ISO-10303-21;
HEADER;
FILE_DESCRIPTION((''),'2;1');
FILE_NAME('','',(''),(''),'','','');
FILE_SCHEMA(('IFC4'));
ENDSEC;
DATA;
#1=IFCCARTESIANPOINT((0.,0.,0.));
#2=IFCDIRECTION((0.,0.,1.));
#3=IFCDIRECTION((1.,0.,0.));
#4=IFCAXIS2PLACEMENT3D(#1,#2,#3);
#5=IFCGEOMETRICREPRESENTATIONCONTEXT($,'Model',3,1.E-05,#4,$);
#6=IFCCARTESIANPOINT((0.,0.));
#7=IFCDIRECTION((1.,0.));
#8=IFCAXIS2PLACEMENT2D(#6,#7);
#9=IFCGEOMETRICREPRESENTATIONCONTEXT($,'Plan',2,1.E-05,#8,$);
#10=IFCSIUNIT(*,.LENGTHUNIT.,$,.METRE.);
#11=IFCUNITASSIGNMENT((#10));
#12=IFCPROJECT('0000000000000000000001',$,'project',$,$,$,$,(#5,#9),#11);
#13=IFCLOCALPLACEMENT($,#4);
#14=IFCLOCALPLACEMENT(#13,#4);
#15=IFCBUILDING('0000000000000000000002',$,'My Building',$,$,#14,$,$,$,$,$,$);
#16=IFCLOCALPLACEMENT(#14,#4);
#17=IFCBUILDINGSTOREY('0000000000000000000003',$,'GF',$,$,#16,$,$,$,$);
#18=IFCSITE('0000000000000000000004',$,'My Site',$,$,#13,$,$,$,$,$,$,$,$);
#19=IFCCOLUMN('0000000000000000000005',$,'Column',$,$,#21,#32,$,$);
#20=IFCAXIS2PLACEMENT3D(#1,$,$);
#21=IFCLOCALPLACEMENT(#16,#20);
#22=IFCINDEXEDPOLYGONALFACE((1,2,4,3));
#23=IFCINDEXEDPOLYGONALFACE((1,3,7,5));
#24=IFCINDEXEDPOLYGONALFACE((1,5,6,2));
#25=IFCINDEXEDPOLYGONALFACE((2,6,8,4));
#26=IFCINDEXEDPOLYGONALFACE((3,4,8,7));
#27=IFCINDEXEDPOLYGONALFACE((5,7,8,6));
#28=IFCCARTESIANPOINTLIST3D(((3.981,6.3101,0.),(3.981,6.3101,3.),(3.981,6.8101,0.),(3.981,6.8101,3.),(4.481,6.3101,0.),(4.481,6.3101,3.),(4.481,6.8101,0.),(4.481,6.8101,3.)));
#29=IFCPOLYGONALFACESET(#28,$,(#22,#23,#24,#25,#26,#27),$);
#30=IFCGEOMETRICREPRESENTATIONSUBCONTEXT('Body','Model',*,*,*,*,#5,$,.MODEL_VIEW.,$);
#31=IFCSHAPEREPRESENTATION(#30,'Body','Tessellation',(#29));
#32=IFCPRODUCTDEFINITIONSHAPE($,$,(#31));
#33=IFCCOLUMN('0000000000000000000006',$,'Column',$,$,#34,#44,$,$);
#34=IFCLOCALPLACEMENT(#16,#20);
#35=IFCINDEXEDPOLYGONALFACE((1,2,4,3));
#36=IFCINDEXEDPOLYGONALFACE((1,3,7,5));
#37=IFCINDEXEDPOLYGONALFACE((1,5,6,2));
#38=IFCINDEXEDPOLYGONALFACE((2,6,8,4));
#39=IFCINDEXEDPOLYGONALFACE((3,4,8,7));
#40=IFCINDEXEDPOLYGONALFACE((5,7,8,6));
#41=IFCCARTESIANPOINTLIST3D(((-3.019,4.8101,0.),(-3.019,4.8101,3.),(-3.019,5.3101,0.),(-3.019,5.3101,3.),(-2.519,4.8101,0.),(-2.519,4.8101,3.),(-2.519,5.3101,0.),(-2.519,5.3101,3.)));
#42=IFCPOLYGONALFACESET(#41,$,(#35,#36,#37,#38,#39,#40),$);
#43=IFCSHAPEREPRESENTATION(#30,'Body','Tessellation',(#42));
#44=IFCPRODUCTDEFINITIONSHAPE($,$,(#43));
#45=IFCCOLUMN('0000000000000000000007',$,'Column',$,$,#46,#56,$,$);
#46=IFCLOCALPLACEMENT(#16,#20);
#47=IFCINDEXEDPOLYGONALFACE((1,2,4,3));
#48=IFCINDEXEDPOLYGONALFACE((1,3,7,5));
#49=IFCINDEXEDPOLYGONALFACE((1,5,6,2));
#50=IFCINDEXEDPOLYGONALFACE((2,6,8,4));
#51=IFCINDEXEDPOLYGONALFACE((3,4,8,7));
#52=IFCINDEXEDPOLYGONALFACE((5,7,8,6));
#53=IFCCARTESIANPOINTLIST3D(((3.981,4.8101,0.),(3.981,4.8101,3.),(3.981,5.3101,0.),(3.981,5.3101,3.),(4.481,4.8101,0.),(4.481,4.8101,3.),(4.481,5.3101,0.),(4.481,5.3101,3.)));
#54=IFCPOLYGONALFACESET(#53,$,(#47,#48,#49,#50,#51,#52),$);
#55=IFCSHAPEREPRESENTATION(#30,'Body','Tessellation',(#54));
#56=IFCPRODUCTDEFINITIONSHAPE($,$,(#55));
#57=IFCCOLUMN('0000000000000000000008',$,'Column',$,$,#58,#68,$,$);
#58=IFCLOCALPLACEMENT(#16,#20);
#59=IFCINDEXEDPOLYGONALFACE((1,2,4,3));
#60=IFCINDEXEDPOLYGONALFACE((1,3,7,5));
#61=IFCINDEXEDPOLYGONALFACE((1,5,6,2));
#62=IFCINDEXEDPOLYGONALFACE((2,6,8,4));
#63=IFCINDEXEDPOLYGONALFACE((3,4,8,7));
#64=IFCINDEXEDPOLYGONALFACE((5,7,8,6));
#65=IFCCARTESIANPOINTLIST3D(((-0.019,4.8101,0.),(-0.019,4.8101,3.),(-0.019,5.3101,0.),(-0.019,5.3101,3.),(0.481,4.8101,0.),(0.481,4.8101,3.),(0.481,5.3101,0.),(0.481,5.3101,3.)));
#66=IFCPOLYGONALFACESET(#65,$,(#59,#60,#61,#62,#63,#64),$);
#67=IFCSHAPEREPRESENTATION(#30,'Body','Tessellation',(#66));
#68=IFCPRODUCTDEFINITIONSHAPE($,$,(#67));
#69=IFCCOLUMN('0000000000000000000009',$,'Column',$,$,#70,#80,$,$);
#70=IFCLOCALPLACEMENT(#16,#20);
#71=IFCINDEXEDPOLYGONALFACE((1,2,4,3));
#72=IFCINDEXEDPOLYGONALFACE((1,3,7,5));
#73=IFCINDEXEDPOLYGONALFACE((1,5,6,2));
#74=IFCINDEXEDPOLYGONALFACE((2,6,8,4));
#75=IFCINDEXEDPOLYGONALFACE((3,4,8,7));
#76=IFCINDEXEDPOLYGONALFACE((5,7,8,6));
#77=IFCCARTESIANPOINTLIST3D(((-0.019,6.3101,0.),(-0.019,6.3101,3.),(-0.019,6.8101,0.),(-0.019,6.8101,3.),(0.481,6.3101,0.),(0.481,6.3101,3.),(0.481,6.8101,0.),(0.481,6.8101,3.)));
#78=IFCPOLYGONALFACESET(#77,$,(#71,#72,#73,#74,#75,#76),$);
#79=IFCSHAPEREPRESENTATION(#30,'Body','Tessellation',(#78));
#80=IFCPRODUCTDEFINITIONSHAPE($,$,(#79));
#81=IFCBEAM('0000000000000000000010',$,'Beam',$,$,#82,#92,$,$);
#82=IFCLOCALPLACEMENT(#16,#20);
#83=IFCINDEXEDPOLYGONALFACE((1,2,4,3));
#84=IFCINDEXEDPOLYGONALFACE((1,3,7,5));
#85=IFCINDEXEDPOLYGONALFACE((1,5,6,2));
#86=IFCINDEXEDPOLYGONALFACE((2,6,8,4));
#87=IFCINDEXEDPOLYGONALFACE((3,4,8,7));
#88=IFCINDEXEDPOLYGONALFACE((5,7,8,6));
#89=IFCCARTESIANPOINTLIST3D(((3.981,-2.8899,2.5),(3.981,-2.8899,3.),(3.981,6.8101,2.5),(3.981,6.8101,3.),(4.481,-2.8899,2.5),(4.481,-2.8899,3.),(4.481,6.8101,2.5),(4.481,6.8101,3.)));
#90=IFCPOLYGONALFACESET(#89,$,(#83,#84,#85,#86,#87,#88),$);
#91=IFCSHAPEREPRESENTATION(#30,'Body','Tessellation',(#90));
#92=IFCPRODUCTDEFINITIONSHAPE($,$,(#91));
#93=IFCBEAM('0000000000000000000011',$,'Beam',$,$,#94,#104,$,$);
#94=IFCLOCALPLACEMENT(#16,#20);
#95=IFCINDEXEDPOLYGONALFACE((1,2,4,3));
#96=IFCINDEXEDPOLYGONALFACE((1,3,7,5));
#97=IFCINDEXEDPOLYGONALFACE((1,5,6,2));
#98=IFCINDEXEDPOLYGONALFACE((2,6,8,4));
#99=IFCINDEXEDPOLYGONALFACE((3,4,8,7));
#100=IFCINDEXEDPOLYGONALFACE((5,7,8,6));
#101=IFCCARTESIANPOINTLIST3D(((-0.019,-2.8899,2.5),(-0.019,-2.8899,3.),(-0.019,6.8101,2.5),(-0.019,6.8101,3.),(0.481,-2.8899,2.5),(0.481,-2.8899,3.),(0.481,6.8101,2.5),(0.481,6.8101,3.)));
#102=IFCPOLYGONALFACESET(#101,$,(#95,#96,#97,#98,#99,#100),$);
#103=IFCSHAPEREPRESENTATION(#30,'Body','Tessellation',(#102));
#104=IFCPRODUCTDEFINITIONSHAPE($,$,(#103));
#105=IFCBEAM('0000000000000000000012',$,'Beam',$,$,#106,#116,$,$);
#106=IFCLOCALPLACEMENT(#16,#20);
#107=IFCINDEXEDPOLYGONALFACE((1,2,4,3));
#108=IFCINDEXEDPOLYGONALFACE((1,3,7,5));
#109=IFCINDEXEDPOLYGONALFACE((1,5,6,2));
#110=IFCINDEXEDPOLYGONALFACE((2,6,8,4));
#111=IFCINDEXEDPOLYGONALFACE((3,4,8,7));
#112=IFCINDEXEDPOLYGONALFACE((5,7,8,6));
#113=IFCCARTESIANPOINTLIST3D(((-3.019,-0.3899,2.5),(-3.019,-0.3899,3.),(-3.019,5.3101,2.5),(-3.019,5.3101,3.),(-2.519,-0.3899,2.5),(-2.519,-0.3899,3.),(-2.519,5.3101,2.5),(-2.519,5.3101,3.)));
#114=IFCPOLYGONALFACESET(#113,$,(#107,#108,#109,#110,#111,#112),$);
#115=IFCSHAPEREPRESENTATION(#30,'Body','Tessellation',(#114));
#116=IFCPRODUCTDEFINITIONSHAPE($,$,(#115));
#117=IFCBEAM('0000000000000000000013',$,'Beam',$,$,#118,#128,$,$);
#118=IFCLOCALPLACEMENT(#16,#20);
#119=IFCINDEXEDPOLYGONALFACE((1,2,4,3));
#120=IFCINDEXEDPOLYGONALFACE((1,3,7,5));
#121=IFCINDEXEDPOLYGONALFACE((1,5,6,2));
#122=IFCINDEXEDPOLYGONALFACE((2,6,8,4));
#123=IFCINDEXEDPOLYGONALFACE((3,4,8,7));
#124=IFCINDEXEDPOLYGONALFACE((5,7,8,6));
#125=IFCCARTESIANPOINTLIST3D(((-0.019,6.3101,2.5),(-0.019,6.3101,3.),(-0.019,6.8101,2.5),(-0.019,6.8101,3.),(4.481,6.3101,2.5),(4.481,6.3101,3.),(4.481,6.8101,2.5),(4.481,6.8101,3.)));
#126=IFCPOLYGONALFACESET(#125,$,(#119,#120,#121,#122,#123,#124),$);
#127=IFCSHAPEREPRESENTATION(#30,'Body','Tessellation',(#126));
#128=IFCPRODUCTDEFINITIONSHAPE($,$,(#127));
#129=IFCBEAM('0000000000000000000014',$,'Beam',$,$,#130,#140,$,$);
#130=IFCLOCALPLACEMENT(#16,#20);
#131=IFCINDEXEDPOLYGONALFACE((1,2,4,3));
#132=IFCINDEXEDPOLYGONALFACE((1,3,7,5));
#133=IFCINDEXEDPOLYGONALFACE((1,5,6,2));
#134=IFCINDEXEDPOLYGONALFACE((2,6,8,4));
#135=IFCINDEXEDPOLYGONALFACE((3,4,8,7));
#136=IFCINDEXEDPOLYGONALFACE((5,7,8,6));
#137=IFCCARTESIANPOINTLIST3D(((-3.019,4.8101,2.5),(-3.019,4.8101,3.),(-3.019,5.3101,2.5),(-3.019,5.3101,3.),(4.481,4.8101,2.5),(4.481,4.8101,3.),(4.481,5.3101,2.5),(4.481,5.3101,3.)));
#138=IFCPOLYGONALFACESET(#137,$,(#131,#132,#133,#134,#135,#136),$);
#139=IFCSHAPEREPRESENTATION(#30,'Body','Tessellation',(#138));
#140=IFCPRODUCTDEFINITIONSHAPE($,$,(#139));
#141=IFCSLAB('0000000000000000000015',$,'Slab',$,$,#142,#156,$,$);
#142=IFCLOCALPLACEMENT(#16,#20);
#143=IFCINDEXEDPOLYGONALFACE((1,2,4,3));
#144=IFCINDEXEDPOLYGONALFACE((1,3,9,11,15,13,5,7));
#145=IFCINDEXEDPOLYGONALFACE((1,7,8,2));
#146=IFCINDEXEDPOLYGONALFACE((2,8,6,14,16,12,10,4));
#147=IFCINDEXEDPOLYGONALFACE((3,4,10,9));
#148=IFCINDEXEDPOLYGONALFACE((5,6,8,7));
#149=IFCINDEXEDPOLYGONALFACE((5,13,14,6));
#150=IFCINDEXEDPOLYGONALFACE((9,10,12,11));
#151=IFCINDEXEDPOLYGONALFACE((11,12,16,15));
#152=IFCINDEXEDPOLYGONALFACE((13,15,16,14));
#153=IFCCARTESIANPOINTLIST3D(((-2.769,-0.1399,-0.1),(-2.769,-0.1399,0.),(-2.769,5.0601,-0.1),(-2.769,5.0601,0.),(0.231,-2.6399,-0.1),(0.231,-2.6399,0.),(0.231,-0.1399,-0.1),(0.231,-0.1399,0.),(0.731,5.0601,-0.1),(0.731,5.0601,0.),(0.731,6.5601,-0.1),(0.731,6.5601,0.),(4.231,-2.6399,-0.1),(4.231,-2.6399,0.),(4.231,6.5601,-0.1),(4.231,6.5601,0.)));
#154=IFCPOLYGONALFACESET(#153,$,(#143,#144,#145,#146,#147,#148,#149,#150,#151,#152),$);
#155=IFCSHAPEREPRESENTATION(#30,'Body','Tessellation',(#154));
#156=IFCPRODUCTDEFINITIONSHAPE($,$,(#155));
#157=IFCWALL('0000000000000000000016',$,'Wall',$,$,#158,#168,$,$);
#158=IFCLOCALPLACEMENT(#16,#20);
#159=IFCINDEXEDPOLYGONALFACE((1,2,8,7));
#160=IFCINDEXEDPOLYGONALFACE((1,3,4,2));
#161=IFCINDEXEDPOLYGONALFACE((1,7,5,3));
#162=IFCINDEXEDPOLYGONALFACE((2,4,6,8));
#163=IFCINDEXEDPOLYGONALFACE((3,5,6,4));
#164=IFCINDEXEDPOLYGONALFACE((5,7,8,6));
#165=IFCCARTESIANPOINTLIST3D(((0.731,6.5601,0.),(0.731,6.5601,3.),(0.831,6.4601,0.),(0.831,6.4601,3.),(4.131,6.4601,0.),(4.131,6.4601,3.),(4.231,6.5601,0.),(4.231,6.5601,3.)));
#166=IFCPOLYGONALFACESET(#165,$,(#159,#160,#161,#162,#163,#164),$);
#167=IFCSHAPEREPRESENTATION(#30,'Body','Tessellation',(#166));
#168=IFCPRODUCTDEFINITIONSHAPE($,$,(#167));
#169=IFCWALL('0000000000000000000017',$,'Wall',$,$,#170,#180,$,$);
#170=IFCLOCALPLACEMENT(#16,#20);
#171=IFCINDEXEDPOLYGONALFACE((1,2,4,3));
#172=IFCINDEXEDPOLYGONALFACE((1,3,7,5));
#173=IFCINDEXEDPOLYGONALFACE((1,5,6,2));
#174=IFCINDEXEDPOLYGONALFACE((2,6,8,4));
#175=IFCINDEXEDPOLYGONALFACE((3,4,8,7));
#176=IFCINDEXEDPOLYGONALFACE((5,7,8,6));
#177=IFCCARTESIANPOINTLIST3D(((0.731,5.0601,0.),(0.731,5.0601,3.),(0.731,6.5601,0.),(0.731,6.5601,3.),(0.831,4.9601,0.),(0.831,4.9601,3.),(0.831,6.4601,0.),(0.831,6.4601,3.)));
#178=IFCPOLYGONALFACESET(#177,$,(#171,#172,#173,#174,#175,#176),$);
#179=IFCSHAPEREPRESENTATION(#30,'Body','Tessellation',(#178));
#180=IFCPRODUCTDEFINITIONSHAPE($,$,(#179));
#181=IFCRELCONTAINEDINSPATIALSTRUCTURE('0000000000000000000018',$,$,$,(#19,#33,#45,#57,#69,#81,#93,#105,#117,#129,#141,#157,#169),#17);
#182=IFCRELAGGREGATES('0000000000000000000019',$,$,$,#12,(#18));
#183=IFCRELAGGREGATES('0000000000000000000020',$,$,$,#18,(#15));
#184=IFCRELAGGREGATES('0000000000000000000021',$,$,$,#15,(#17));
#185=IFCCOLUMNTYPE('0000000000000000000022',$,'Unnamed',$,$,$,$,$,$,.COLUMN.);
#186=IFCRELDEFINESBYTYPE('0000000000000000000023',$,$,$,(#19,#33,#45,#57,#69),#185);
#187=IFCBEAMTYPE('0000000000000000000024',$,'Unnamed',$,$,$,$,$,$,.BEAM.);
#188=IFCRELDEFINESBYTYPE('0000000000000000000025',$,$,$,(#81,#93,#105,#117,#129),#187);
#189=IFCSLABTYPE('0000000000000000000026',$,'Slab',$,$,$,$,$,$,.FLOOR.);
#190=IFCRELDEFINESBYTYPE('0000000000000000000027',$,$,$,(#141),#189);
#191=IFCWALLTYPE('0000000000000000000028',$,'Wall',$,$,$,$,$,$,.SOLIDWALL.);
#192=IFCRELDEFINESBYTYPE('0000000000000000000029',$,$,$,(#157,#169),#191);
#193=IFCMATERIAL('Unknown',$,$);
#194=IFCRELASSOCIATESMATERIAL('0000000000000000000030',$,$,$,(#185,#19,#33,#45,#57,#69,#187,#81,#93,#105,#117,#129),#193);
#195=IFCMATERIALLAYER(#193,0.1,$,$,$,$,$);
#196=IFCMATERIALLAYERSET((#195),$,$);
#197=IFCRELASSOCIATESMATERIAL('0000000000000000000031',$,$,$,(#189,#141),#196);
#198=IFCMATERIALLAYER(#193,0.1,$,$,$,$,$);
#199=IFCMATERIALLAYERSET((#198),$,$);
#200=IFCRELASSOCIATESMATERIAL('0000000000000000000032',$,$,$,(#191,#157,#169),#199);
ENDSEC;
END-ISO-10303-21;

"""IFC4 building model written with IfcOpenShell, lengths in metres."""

from ifc_helpers import new_model, si_unit, frame, origin_with_axes, origin_2d_with_axis, place, context, subcontext, project, spatial, line, indexed_curve, rectangle, outline, extrude, material, layer, layer_set, layer_usage, material_profile, profile_set, profile_usage, type_object, element, save


model = new_model("IFC4")

# Units and contexts
model_context = context("Model", 3, precision=1e-05, world=origin_with_axes())
plan_context = context("Plan", 2, precision=1e-05, world=origin_2d_with_axis())
body_context_1 = subcontext(model_context, "Body", "Model", "MODEL_VIEW")
ifc_project = project(units=[si_unit("LENGTHUNIT", "METRE")], contexts=[model_context, plan_context])

# Site, building, storey
site_placement = place(None, origin_with_axes())
site = spatial("IfcSite", under=ifc_project, at=site_placement, Name="My Site")
building_placement = place(site_placement, origin_with_axes())
building = spatial("IfcBuilding", under=site, at=building_placement, Name="My Building")
storey_placement = place(building_placement, origin_with_axes())
storey = spatial("IfcBuildingStorey", under=building, at=storey_placement, Name="GF")

# Columns
ifc_material_1 = material(Name="Unknown")
ifc_material_profile_1 = material_profile(ifc_material_1, rectangle(XDim=0.5, YDim=0.5))
ifc_profile_set_1 = profile_set([ifc_material_profile_1])
ifc_profile_usage_1 = profile_usage(ifc_profile_set_1, cardinal=5)
column_type = type_object("IfcColumnType", Name="Unnamed", PredefinedType="COLUMN", material=ifc_profile_set_1)
column_1_placement = place(storey_placement, frame((4.231, 6.5601, 0.0), z_axis=(0.0, 0.0, 1.0), x_axis=(1.0, 0.0, 0.0)))
element("IfcColumn", 1, at=column_1_placement, inside=storey, type_object=column_type, material=ifc_profile_usage_1, Name="Column", context=body_context_1, shape_type="SweptSolid", body=[
    extrude(rectangle(XDim=0.5, YDim=0.5), origin_with_axes(), (0.0, 0.0, 1.0), 3.0),
])
ifc_profile_usage_2 = profile_usage(ifc_profile_set_1, cardinal=5)
column_2_placement = place(storey_placement, frame((-2.769, 5.0601, 0.0), z_axis=(0.0, 0.0, 1.0), x_axis=(1.0, 0.0, 0.0)))
element("IfcColumn", 2, at=column_2_placement, inside=storey, type_object=column_type, material=ifc_profile_usage_2, Name="Column", context=body_context_1, shape_type="SweptSolid", body=[
    extrude(rectangle(XDim=0.5, YDim=0.5), origin_with_axes(), (0.0, 0.0, 1.0), 3.0),
])
ifc_profile_usage_3 = profile_usage(ifc_profile_set_1, cardinal=5)
column_3_placement = place(storey_placement, frame((4.231, 5.0601, 0.0), z_axis=(0.0, 0.0, 1.0), x_axis=(1.0, 0.0, 0.0)))
element("IfcColumn", 3, at=column_3_placement, inside=storey, type_object=column_type, material=ifc_profile_usage_3, Name="Column", context=body_context_1, shape_type="SweptSolid", body=[
    extrude(rectangle(XDim=0.5, YDim=0.5), origin_with_axes(), (0.0, 0.0, 1.0), 3.0),
])
ifc_profile_usage_4 = profile_usage(ifc_profile_set_1, cardinal=5)
column_4_placement = place(storey_placement, frame((0.231, 5.0601, 0.0), z_axis=(0.0, 0.0, 1.0), x_axis=(1.0, 0.0, 0.0)))
element("IfcColumn", 4, at=column_4_placement, inside=storey, type_object=column_type, material=ifc_profile_usage_4, Name="Column", context=body_context_1, shape_type="SweptSolid", body=[
    extrude(rectangle(XDim=0.5, YDim=0.5), origin_with_axes(), (0.0, 0.0, 1.0), 3.0),
])
ifc_profile_usage_5 = profile_usage(ifc_profile_set_1, cardinal=5)
column_5_placement = place(storey_placement, frame((0.231, 6.5601, 0.0), z_axis=(0.0, 0.0, 1.0), x_axis=(1.0, 0.0, 0.0)))
element("IfcColumn", 5, at=column_5_placement, inside=storey, type_object=column_type, material=ifc_profile_usage_5, Name="Column", context=body_context_1, shape_type="SweptSolid", body=[
    extrude(rectangle(XDim=0.5, YDim=0.5), origin_with_axes(), (0.0, 0.0, 1.0), 3.0),
])

# Beams
ifc_material_profile_2 = material_profile(ifc_material_1, rectangle(XDim=0.5, YDim=0.5))
ifc_profile_set_2 = profile_set([ifc_material_profile_2])
ifc_profile_usage_6 = profile_usage(ifc_profile_set_2, cardinal=7)
beam_type = type_object("IfcBeamType", Name="Unnamed", PredefinedType="BEAM", material=ifc_profile_set_2)
beam_1_placement = place(storey_placement, frame((4.481, 6.8101, 3.0), z_axis=(0.0, -1.0, 0.0), x_axis=(1.0, 0.0, 0.0)))
element("IfcBeam", 6, at=beam_1_placement, inside=storey, type_object=beam_type, material=ifc_profile_usage_6, Name="Beam", context=body_context_1, shape_type="SweptSolid", body=[
    extrude(rectangle(XDim=0.5, YDim=0.5), frame((-0.25, -0.25, 0.0), z_axis=(0.0, 0.0, 1.0), x_axis=(1.0, 0.0, 0.0)), (0.0, 0.0, 1.0), 9.7),
])
ifc_profile_usage_7 = profile_usage(ifc_profile_set_2, cardinal=7)
beam_2_placement = place(storey_placement, frame((0.481, 6.8101, 3.0), z_axis=(0.0, -1.0, 0.0), x_axis=(1.0, 0.0, 0.0)))
element("IfcBeam", 7, at=beam_2_placement, inside=storey, type_object=beam_type, material=ifc_profile_usage_7, Name="Beam", context=body_context_1, shape_type="SweptSolid", body=[
    extrude(rectangle(XDim=0.5, YDim=0.5), frame((-0.25, -0.25, 0.0), z_axis=(0.0, 0.0, 1.0), x_axis=(1.0, 0.0, 0.0)), (0.0, 0.0, 1.0), 9.7),
])
ifc_profile_usage_8 = profile_usage(ifc_profile_set_2, cardinal=7)
beam_3_placement = place(storey_placement, frame((-2.519, 5.3101, 3.0), z_axis=(0.0, -1.0, 0.0), x_axis=(1.0, 0.0, 0.0)))
element("IfcBeam", 8, at=beam_3_placement, inside=storey, type_object=beam_type, material=ifc_profile_usage_8, Name="Beam", context=body_context_1, shape_type="SweptSolid", body=[
    extrude(rectangle(XDim=0.5, YDim=0.5), frame((-0.25, -0.25, 0.0), z_axis=(0.0, 0.0, 1.0), x_axis=(1.0, 0.0, 0.0)), (0.0, 0.0, 1.0), 5.7),
])
ifc_profile_usage_9 = profile_usage(ifc_profile_set_2, cardinal=7)
beam_4_placement = place(storey_placement, frame((4.481, 6.3101, 3.0), z_axis=(-1.0, 0.000001, 0.0), x_axis=(-0.000001, -1.0, 0.000001)))
element("IfcBeam", 9, at=beam_4_placement, inside=storey, type_object=beam_type, material=ifc_profile_usage_9, Name="Beam", context=body_context_1, shape_type="SweptSolid", body=[
    extrude(rectangle(XDim=0.5, YDim=0.5), frame((-0.25, -0.25, 0.0), z_axis=(0.0, 0.0, 1.0), x_axis=(1.0, 0.0, 0.0)), (0.0, 0.0, 1.0), 4.5),
])
ifc_profile_usage_10 = profile_usage(ifc_profile_set_2, cardinal=7)
beam_5_placement = place(storey_placement, frame((4.481, 4.8101, 3.0), z_axis=(-1.0, 0.0, 0.0), x_axis=(0.0, -1.0, 0.0)))
element("IfcBeam", 10, at=beam_5_placement, inside=storey, type_object=beam_type, material=ifc_profile_usage_10, Name="Beam", context=body_context_1, shape_type="SweptSolid", body=[
    extrude(rectangle(XDim=0.5, YDim=0.5), frame((-0.25, -0.25, 0.0), z_axis=(0.0, 0.0, 1.0), x_axis=(1.0, 0.0, 0.0)), (0.0, 0.0, 1.0), 7.5),
])

# Slab
ifc_layer_1 = layer(ifc_material_1, 0.1)
ifc_layer_set_1 = layer_set([ifc_layer_1])
ifc_layer_usage_1 = layer_usage(ifc_layer_set_1, "AXIS3", "POSITIVE", -0.1)
slab_type = type_object("IfcSlabType", Name="Slab", PredefinedType="FLOOR", material=ifc_layer_set_1)
slab_placement = place(storey_placement, frame((4.231, 6.5601, 0.0), z_axis=(0.0, 0.0, 1.0), x_axis=(1.0, 0.0, 0.0)))
element("IfcSlab", 11, at=slab_placement, inside=storey, type_object=slab_type, material=ifc_layer_usage_1, Name="Slab", context=body_context_1, shape_type="SweptSolid", body=[
    extrude(outline(indexed_curve([(0.0, 0.0), (-3.5, 0.0), (-3.5, -1.5), (-7.0, -1.5), (-7.0, -6.7), (-4.0, -6.7), (-4.0, -9.2), (0.0, -9.2), (0.0, 0.0)])), frame((0.0, 0.0, -0.1), z_axis=(0.0, 0.0, 1.0), x_axis=(1.0, 0.0, 0.0)), (0.0, 0.0, 1.0), 0.1),
])

# Walls
ifc_layer_2 = layer(ifc_material_1, 0.1)
ifc_layer_set_2 = layer_set([ifc_layer_2])
ifc_layer_usage_2 = layer_usage(ifc_layer_set_2, "AXIS2", "POSITIVE", 0.0)
wall_type = type_object("IfcWallType", Name="Wall", PredefinedType="SOLIDWALL", material=ifc_layer_set_2)
wall_1_placement = place(storey_placement, frame((4.231, 6.5601, 0.0), z_axis=(0.0, 0.0, 1.0), x_axis=(-1.0, 0.0, 0.0)))
element("IfcWall", 12, at=wall_1_placement, inside=storey, type_object=wall_type, material=ifc_layer_usage_2, Name="Wall", context=body_context_1, shape_type="SweptSolid", body=[
    extrude(outline(indexed_curve([(0.0, 0.0), (0.1, 0.1), (3.4, 0.1), (3.5, 0.0)], segments=[line(1, 2, 3, 4, 1)])), origin_with_axes(), (0.0, 0.0, 1.0), 3.0),
])
ifc_layer_usage_3 = layer_usage(ifc_layer_set_2, "AXIS2", "POSITIVE", 0.0)
wall_2_placement = place(storey_placement, frame((0.731, 6.5601, 0.0), z_axis=(0.0, 0.0, 1.0), x_axis=(0.0, -1.0, 0.0)))
element("IfcWall", 13, at=wall_2_placement, inside=storey, type_object=wall_type, material=ifc_layer_usage_3, Name="Wall", context=body_context_1, shape_type="SweptSolid", body=[
    extrude(outline(indexed_curve([(0.0, 0.0), (0.1, 0.1), (1.6, 0.1), (1.5, 0.0)], segments=[line(1, 2, 3, 4, 1)])), origin_with_axes(), (0.0, 0.0, 1.0), 3.0),
])

save(model, "model.ifc")
